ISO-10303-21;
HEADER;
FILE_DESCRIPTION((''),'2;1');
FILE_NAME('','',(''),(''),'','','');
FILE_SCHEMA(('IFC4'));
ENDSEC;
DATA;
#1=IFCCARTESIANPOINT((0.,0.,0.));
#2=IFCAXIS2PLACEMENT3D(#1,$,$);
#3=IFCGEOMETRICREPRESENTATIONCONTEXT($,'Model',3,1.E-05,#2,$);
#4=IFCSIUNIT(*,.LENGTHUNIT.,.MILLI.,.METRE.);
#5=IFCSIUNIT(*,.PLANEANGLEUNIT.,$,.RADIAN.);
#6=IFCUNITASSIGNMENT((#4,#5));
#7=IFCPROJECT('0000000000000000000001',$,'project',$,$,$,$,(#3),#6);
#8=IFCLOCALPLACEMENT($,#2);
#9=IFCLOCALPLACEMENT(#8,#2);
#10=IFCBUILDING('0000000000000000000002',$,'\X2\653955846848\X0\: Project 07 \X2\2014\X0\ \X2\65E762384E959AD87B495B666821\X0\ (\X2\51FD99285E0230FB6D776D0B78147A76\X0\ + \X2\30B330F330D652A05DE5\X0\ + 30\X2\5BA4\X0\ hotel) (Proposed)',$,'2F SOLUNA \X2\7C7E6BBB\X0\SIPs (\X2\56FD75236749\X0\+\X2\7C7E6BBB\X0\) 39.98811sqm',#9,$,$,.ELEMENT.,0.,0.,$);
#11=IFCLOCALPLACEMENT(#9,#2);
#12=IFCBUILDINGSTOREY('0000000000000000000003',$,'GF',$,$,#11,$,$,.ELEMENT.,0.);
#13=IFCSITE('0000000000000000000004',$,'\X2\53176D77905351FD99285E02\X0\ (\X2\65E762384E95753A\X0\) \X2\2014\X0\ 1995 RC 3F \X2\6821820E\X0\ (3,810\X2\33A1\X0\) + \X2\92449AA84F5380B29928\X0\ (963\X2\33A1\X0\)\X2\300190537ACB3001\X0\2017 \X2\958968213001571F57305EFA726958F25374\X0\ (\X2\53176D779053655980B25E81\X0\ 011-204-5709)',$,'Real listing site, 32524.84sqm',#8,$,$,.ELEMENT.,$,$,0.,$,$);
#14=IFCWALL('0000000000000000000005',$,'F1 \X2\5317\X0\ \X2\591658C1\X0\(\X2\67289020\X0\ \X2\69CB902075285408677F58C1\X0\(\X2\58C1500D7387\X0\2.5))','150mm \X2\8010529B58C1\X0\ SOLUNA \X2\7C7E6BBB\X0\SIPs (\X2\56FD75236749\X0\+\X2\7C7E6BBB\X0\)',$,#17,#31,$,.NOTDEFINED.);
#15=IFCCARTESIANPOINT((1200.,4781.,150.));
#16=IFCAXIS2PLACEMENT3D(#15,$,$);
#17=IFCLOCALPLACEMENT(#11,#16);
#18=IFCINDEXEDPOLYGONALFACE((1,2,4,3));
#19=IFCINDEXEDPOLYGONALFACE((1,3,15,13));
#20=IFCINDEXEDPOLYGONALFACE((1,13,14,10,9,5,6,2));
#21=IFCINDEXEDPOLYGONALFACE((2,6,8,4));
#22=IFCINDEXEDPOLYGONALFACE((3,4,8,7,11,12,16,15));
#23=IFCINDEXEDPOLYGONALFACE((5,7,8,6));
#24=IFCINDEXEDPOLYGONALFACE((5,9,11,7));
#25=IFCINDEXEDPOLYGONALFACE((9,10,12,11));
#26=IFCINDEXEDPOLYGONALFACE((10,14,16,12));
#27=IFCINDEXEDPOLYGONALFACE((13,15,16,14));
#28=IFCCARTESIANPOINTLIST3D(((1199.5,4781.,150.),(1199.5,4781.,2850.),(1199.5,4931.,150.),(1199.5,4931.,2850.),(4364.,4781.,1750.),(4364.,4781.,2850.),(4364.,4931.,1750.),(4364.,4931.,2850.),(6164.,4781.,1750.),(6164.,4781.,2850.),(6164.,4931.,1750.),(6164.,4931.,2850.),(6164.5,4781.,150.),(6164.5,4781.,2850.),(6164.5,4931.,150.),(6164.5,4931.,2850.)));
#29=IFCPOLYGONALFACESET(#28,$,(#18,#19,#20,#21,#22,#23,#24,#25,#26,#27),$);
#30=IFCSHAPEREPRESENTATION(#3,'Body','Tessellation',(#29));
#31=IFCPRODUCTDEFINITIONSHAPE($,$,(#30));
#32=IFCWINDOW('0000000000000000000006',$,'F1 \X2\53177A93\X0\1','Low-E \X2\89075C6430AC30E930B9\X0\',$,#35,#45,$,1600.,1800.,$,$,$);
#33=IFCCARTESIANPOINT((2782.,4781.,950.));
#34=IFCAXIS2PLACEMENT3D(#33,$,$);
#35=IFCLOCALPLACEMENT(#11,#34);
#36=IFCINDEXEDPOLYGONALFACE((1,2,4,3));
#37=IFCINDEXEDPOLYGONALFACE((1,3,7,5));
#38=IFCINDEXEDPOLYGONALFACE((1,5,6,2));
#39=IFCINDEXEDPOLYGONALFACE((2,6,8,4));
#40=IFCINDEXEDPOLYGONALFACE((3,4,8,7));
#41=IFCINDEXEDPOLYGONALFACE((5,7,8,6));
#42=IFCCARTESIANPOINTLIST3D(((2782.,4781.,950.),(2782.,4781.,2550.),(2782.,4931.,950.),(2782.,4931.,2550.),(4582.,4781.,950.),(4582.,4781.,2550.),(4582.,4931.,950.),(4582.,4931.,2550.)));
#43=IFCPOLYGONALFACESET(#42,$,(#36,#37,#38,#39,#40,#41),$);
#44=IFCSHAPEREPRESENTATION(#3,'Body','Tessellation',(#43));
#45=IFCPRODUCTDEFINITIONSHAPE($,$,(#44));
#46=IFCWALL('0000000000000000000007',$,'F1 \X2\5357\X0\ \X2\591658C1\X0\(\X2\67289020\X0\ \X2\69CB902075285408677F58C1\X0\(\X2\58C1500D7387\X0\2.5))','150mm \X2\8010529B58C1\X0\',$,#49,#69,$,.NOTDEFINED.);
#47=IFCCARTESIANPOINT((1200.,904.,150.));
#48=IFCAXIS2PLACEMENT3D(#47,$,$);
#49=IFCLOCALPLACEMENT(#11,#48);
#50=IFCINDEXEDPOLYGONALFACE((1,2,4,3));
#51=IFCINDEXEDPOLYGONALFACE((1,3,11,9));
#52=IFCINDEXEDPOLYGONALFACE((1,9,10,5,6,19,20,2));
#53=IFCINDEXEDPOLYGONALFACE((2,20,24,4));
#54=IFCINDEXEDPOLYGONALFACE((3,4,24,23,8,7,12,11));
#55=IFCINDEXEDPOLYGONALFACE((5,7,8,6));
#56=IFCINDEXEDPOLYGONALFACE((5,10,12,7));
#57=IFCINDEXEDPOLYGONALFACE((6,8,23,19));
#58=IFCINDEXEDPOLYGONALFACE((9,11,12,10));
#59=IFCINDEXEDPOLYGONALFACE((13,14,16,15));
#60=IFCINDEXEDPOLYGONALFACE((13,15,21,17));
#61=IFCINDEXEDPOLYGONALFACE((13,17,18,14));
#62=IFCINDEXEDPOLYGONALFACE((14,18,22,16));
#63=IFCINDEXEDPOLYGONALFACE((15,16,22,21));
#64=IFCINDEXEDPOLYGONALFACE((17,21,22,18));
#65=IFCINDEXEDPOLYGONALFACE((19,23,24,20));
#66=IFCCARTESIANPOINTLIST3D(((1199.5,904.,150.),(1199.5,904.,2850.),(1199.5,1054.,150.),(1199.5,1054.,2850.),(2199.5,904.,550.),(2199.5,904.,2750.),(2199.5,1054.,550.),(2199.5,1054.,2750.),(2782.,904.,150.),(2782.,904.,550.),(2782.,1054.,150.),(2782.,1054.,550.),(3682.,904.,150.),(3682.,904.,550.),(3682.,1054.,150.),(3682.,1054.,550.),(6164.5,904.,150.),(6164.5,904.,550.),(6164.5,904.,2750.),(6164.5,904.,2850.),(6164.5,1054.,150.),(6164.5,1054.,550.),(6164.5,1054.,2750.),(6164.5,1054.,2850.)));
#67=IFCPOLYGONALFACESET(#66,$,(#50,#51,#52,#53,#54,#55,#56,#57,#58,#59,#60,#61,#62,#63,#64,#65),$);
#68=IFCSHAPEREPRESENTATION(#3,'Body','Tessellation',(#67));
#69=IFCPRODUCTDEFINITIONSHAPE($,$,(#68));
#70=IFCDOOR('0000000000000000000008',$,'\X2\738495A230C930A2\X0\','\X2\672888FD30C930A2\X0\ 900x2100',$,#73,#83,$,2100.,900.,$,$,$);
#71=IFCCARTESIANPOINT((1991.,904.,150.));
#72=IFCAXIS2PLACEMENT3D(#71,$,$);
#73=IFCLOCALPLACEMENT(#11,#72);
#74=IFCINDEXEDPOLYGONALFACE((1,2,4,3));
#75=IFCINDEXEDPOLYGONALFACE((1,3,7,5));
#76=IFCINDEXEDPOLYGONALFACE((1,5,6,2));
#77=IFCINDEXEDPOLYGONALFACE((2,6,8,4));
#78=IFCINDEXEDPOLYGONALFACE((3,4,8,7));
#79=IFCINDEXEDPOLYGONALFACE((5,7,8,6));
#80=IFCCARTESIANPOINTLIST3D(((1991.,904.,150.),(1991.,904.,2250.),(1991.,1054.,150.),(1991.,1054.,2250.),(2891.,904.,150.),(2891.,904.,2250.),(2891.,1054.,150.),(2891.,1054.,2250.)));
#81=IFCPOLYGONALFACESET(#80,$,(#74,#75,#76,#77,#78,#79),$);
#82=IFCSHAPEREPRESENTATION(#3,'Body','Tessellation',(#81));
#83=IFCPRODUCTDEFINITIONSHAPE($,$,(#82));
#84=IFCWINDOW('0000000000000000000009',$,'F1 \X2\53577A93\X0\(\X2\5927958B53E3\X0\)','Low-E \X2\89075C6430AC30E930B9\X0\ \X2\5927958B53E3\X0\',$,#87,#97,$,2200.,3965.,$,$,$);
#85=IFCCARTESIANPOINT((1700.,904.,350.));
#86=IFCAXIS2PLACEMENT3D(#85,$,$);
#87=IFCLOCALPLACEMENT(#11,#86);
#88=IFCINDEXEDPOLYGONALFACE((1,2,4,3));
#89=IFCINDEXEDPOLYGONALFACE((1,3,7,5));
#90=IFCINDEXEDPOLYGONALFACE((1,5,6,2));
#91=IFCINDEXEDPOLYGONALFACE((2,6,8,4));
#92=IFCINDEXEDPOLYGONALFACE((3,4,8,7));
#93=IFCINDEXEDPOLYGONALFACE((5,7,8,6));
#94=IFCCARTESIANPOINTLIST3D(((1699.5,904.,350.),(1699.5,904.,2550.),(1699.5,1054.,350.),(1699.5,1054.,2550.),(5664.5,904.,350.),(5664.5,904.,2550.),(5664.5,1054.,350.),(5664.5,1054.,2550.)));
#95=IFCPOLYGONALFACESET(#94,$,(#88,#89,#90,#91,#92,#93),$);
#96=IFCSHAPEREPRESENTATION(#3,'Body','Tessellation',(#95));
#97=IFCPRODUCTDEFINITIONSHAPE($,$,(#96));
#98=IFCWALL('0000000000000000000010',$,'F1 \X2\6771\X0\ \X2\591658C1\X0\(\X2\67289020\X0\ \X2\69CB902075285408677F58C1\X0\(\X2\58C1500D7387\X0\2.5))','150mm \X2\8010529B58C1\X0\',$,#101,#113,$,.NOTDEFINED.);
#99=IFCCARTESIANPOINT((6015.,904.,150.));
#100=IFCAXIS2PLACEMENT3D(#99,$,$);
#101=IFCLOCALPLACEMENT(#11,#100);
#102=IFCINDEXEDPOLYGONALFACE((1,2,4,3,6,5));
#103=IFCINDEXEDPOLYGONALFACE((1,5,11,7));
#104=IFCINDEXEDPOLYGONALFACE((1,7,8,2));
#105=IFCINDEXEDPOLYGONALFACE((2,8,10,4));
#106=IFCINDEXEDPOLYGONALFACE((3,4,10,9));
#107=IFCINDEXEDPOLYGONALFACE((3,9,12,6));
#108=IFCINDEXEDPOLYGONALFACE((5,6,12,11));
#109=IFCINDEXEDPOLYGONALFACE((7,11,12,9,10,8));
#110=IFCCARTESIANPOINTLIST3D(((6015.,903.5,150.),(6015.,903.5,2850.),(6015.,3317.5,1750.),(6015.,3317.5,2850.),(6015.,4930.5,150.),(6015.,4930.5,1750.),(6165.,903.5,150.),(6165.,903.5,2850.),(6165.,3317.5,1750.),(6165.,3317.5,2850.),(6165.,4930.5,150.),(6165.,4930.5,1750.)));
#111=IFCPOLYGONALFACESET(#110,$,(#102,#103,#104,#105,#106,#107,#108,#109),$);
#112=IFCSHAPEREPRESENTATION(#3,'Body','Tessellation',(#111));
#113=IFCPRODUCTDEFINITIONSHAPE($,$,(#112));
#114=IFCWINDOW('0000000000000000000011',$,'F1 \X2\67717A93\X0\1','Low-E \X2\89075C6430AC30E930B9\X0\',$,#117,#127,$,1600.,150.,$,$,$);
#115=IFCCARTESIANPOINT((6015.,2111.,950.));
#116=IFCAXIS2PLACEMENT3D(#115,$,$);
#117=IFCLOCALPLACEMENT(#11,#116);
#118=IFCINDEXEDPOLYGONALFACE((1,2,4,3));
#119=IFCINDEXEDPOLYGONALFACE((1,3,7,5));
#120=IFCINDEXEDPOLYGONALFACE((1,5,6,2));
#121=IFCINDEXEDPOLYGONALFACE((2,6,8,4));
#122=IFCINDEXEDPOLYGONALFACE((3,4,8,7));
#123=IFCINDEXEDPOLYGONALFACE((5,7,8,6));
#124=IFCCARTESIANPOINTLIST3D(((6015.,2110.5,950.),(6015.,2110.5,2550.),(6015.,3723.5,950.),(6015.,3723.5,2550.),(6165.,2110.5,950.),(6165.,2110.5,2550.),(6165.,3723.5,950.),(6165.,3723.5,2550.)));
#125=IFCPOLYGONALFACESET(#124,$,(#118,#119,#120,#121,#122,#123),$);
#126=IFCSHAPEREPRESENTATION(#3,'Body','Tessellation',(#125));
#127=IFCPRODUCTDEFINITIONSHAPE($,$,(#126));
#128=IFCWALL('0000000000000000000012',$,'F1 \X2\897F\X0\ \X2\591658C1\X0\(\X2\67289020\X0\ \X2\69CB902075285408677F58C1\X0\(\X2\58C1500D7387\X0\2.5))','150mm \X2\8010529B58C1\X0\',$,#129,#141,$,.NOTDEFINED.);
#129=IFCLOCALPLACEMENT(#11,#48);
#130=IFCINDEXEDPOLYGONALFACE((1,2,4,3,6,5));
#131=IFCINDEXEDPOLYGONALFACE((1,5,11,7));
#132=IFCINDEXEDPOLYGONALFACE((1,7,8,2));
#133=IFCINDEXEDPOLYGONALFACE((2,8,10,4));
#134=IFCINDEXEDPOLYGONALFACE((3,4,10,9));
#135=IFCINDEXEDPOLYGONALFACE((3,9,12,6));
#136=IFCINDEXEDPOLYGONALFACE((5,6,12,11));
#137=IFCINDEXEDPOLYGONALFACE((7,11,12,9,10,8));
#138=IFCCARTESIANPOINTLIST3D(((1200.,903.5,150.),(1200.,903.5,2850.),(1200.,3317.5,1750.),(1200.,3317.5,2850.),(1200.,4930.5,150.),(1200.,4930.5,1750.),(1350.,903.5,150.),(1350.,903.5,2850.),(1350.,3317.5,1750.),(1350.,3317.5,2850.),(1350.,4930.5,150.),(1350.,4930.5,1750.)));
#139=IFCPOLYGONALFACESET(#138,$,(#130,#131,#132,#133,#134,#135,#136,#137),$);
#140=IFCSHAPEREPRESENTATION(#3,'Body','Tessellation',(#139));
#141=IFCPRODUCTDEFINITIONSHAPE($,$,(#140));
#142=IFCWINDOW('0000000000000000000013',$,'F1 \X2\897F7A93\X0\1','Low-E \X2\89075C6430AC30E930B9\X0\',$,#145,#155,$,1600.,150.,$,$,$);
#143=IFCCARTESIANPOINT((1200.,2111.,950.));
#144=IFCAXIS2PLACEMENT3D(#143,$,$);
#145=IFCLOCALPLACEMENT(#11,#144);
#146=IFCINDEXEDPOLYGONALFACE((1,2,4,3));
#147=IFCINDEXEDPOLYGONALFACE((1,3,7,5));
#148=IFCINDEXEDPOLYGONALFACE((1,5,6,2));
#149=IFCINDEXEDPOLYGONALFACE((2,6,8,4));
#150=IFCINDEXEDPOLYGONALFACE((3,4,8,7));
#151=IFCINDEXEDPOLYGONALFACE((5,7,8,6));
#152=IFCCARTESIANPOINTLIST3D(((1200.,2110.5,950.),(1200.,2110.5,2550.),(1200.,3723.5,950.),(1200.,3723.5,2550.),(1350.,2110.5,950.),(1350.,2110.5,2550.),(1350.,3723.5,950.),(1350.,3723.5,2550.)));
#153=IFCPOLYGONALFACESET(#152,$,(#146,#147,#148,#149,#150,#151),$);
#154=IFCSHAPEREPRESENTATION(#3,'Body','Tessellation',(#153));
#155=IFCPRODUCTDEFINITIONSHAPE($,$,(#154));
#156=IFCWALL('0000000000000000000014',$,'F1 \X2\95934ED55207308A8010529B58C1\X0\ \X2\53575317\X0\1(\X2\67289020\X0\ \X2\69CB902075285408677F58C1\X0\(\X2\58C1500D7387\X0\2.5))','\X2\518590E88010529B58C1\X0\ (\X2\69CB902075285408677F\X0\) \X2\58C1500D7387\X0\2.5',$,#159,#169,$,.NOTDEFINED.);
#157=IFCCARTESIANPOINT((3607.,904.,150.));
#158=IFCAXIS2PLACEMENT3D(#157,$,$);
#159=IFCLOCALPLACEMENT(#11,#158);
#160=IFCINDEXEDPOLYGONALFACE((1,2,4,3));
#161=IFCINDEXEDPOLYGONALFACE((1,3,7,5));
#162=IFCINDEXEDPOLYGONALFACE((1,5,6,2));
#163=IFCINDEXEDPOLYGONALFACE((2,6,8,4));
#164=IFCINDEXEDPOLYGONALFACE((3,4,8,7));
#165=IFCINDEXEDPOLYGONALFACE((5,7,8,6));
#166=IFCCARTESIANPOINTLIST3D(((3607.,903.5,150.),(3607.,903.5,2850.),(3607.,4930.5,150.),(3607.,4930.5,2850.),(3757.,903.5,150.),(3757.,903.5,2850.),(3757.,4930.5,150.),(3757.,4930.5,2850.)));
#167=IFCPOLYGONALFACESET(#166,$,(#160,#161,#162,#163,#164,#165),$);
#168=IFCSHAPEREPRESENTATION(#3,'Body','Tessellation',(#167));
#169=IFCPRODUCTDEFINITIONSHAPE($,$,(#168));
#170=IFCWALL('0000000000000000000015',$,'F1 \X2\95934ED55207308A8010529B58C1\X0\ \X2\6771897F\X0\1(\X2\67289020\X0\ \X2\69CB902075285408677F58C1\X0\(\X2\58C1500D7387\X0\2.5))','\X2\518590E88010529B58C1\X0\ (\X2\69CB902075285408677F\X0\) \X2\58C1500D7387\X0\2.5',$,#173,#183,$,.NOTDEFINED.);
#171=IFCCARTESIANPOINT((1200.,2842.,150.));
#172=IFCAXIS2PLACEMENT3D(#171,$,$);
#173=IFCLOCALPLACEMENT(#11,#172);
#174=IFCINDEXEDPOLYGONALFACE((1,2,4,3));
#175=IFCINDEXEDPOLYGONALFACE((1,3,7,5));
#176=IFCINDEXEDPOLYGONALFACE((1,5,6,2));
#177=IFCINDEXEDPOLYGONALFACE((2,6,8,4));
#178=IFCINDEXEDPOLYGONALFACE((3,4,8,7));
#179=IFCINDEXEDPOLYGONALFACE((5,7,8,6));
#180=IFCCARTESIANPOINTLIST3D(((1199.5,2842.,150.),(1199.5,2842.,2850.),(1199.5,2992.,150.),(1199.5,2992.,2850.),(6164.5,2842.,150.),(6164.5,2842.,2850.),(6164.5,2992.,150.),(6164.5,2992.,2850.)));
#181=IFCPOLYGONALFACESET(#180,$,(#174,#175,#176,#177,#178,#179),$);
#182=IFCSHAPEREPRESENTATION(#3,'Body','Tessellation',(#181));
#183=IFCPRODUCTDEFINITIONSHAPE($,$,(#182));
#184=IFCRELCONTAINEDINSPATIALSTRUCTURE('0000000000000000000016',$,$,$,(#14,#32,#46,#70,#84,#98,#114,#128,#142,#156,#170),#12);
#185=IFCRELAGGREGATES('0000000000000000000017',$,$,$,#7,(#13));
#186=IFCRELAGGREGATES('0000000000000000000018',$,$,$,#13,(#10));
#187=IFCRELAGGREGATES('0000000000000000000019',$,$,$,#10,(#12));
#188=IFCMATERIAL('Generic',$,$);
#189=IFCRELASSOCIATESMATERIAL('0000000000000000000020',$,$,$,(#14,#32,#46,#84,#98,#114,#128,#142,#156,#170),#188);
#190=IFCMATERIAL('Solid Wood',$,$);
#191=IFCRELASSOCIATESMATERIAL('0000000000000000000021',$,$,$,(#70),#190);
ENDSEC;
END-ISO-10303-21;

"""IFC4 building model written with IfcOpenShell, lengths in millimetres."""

from ifc_helpers import new_model, si_unit, frame, frame_2d, origin, place, context, project, spatial, rectangle, extrude, material, element, fill, save


model = new_model("IFC4")

# Units and contexts
model_context = context("Model", 3, precision=1e-05, world=origin())
ifc_project = project(units=[si_unit("LENGTHUNIT", "METRE", prefix="MILLI"), si_unit("PLANEANGLEUNIT", "RADIAN")], contexts=[model_context])

# Site, building, storey
site_placement = place(None, origin())
site = spatial("IfcSite", under=ifc_project, at=site_placement, Name="北海道函館市 (旧戸井町) — 1995 RC 3F 校舎 (3,810㎡) + 鉄骨体育館 (963㎡)、道立、2017 閉校、土地建物売却 (北海道教育庁 011-204-5709)", ObjectType="Real listing site, 32524.84sqm", CompositionType="ELEMENT", RefElevation=0.0)
building_placement = place(site_placement, origin())
building = spatial("IfcBuilding", under=site, at=building_placement, Name="改善案: Project 07 — 旧戸井高等学校 (函館市・海洋研究 + コンブ加工 + 30室 hotel) (Proposed)", ObjectType="2F SOLUNA 籾殻SIPs (国産杉+籾殻) 39.98811sqm", CompositionType="ELEMENT", ElevationOfRefHeight=0.0, ElevationOfTerrain=0.0)
storey_placement = place(building_placement, origin())
storey = spatial("IfcBuildingStorey", under=building, at=storey_placement, Name="GF", CompositionType="ELEMENT", Elevation=0.0)

# Shared definitions
ifc_material_1 = material(Name="Generic")

# Wall, opening, window
wall_1_placement = place(storey_placement, frame((1200.0, 4781.0, 150.0)))
wall_1 = element("IfcWall", 1, at=wall_1_placement, inside=storey, material=ifc_material_1, Name="F1 北 外壁(木造 構造用合板壁(壁倍率2.5))", Description="150mm 耐力壁 SOLUNA 籾殻SIPs (国産杉+籾殻)", PredefinedType="NOTDEFINED", context=model_context, shape_type="SweptSolid", body=[
    extrude(rectangle(XDim=4965.0, YDim=150.0, at=frame_2d((2482.0, 75.0))), frame((1200.0, 4781.0, 150.0)), (0.0, 0.0, 1.0), 2700.0),
])
opening_1_placement = place(storey_placement, frame((2782.0, 4781.0, 950.0)))
opening_1 = element("IfcOpeningElement", 2, at=opening_1_placement, cuts=wall_1, PredefinedType="NOTDEFINED", context=model_context, shape_type="SweptSolid", body=[
    extrude(rectangle(XDim=1800.0, YDim=150.0, at=frame_2d((900.0, 75.0))), frame((2782.0, 4781.0, 950.0)), (0.0, 0.0, 1.0), 1600.0),
])
window_1_placement = place(storey_placement, frame((2782.0, 4781.0, 950.0)))
window_1 = element("IfcWindow", 3, at=window_1_placement, inside=storey, material=ifc_material_1, Name="F1 北窓1", Description="Low-E 複層ガラス", OverallHeight=1600.0, OverallWidth=1800.0, context=model_context, shape_type="SweptSolid", body=[
    extrude(rectangle(XDim=1800.0, YDim=150.0, at=frame_2d((900.0, 75.0))), frame((2782.0, 4781.0, 950.0)), (0.0, 0.0, 1.0), 1600.0),
])
fill(opening_1, window_1)

# Wall, openings, door, window
wall_2_placement = place(storey_placement, frame((1200.0, 904.0, 150.0)))
wall_2 = element("IfcWall", 4, at=wall_2_placement, inside=storey, material=ifc_material_1, Name="F1 南 外壁(木造 構造用合板壁(壁倍率2.5))", Description="150mm 耐力壁", PredefinedType="NOTDEFINED", context=model_context, shape_type="SweptSolid", body=[
    extrude(rectangle(XDim=4965.0, YDim=150.0, at=frame_2d((2482.0, 75.0))), frame((1200.0, 904.0, 150.0)), (0.0, 0.0, 1.0), 2700.0),
])
opening_2_placement = place(storey_placement, frame((1991.0, 904.0, 150.0)))
opening_2 = element("IfcOpeningElement", 5, at=opening_2_placement, cuts=wall_2, PredefinedType="NOTDEFINED", context=model_context, shape_type="SweptSolid", body=[
    extrude(rectangle(XDim=900.0, YDim=150.0, at=frame_2d((450.0, 75.0))), frame((1991.0, 904.0, 150.0)), (0.0, 0.0, 1.0), 2100.0),
])
opening_3_placement = place(storey_placement, frame((1700.0, 904.0, 350.0)))
opening_3 = element("IfcOpeningElement", 6, at=opening_3_placement, cuts=wall_2, PredefinedType="NOTDEFINED", context=model_context, shape_type="SweptSolid", body=[
    extrude(rectangle(XDim=3965.0, YDim=150.0, at=frame_2d((1982.0, 75.0))), frame((1700.0, 904.0, 350.0)), (0.0, 0.0, 1.0), 2200.0),
])
ifc_material_2 = material(Name="Solid Wood")
door_placement = place(storey_placement, frame((1991.0, 904.0, 150.0)))
door = element("IfcDoor", 7, at=door_placement, inside=storey, material=ifc_material_2, Name="玄関ドア", Description="木製ドア 900x2100", OverallHeight=2100.0, OverallWidth=900.0, context=model_context, shape_type="SweptSolid", body=[
    extrude(rectangle(XDim=900.0, YDim=150.0, at=frame_2d((450.0, 75.0))), frame((1991.0, 904.0, 150.0)), (0.0, 0.0, 1.0), 2100.0),
])
fill(opening_2, door)
window_2_placement = place(storey_placement, frame((1700.0, 904.0, 350.0)))
window_2 = element("IfcWindow", 8, at=window_2_placement, inside=storey, material=ifc_material_1, Name="F1 南窓(大開口)", Description="Low-E 複層ガラス 大開口", OverallHeight=2200.0, OverallWidth=3965.0, context=model_context, shape_type="SweptSolid", body=[
    extrude(rectangle(XDim=3965.0, YDim=150.0, at=frame_2d((1982.0, 75.0))), frame((1700.0, 904.0, 350.0)), (0.0, 0.0, 1.0), 2200.0),
])
fill(opening_3, window_2)

# Walls, openings, windows
wall_3_placement = place(storey_placement, frame((6015.0, 904.0, 150.0)))
wall_3 = element("IfcWall", 9, at=wall_3_placement, inside=storey, material=ifc_material_1, Name="F1 東 外壁(木造 構造用合板壁(壁倍率2.5))", Description="150mm 耐力壁", PredefinedType="NOTDEFINED", context=model_context, shape_type="SweptSolid", body=[
    extrude(rectangle(XDim=150.0, YDim=4027.0, at=frame_2d((75.0, 2013.0))), frame((6015.0, 904.0, 150.0)), (0.0, 0.0, 1.0), 2700.0),
])
opening_4_placement = place(storey_placement, frame((6015.0, 2111.0, 950.0)))
opening_4 = element("IfcOpeningElement", 10, at=opening_4_placement, cuts=wall_3, PredefinedType="NOTDEFINED", context=model_context, shape_type="SweptSolid", body=[
    extrude(rectangle(XDim=150.0, YDim=1613.0, at=frame_2d((75.0, 806.0))), frame((6015.0, 2111.0, 950.0)), (0.0, 0.0, 1.0), 1600.0),
])
window_3_placement = place(storey_placement, frame((6015.0, 2111.0, 950.0)))
window_3 = element("IfcWindow", 11, at=window_3_placement, inside=storey, material=ifc_material_1, Name="F1 東窓1", Description="Low-E 複層ガラス", OverallHeight=1600.0, OverallWidth=150.0, context=model_context, shape_type="SweptSolid", body=[
    extrude(rectangle(XDim=150.0, YDim=1613.0, at=frame_2d((75.0, 806.0))), frame((6015.0, 2111.0, 950.0)), (0.0, 0.0, 1.0), 1600.0),
])
fill(opening_4, window_3)
wall_4_placement = place(storey_placement, frame((1200.0, 904.0, 150.0)))
wall_4 = element("IfcWall", 12, at=wall_4_placement, inside=storey, material=ifc_material_1, Name="F1 西 外壁(木造 構造用合板壁(壁倍率2.5))", Description="150mm 耐力壁", PredefinedType="NOTDEFINED", context=model_context, shape_type="SweptSolid", body=[
    extrude(rectangle(XDim=150.0, YDim=4027.0, at=frame_2d((75.0, 2013.0))), frame((1200.0, 904.0, 150.0)), (0.0, 0.0, 1.0), 2700.0),
])
opening_5_placement = place(storey_placement, frame((1200.0, 2111.0, 950.0)))
opening_5 = element("IfcOpeningElement", 13, at=opening_5_placement, cuts=wall_4, PredefinedType="NOTDEFINED", context=model_context, shape_type="SweptSolid", body=[
    extrude(rectangle(XDim=150.0, YDim=1613.0, at=frame_2d((75.0, 806.0))), frame((1200.0, 2111.0, 950.0)), (0.0, 0.0, 1.0), 1600.0),
])
window_4_placement = place(storey_placement, frame((1200.0, 2111.0, 950.0)))
window_4 = element("IfcWindow", 14, at=window_4_placement, inside=storey, material=ifc_material_1, Name="F1 西窓1", Description="Low-E 複層ガラス", OverallHeight=1600.0, OverallWidth=150.0, context=model_context, shape_type="SweptSolid", body=[
    extrude(rectangle(XDim=150.0, YDim=1613.0, at=frame_2d((75.0, 806.0))), frame((1200.0, 2111.0, 950.0)), (0.0, 0.0, 1.0), 1600.0),
])
fill(opening_5, window_4)

# Walls
wall_5_placement = place(storey_placement, frame((3607.0, 904.0, 150.0)))
element("IfcWall", 15, at=wall_5_placement, inside=storey, material=ifc_material_1, Name="F1 間仕切り耐力壁 南北1(木造 構造用合板壁(壁倍率2.5))", Description="内部耐力壁 (構造用合板) 壁倍率2.5", PredefinedType="NOTDEFINED", context=model_context, shape_type="SweptSolid", body=[
    extrude(rectangle(XDim=150.0, YDim=4027.0, at=frame_2d((75.0, 2013.0))), frame((3607.0, 904.0, 150.0)), (0.0, 0.0, 1.0), 2700.0),
])
wall_6_placement = place(storey_placement, frame((1200.0, 2842.0, 150.0)))
element("IfcWall", 16, at=wall_6_placement, inside=storey, material=ifc_material_1, Name="F1 間仕切り耐力壁 東西1(木造 構造用合板壁(壁倍率2.5))", Description="内部耐力壁 (構造用合板) 壁倍率2.5", PredefinedType="NOTDEFINED", context=model_context, shape_type="SweptSolid", body=[
    extrude(rectangle(XDim=4965.0, YDim=150.0, at=frame_2d((2482.0, 75.0))), frame((1200.0, 2842.0, 150.0)), (0.0, 0.0, 1.0), 2700.0),
])

save(model, "model.ifc")
